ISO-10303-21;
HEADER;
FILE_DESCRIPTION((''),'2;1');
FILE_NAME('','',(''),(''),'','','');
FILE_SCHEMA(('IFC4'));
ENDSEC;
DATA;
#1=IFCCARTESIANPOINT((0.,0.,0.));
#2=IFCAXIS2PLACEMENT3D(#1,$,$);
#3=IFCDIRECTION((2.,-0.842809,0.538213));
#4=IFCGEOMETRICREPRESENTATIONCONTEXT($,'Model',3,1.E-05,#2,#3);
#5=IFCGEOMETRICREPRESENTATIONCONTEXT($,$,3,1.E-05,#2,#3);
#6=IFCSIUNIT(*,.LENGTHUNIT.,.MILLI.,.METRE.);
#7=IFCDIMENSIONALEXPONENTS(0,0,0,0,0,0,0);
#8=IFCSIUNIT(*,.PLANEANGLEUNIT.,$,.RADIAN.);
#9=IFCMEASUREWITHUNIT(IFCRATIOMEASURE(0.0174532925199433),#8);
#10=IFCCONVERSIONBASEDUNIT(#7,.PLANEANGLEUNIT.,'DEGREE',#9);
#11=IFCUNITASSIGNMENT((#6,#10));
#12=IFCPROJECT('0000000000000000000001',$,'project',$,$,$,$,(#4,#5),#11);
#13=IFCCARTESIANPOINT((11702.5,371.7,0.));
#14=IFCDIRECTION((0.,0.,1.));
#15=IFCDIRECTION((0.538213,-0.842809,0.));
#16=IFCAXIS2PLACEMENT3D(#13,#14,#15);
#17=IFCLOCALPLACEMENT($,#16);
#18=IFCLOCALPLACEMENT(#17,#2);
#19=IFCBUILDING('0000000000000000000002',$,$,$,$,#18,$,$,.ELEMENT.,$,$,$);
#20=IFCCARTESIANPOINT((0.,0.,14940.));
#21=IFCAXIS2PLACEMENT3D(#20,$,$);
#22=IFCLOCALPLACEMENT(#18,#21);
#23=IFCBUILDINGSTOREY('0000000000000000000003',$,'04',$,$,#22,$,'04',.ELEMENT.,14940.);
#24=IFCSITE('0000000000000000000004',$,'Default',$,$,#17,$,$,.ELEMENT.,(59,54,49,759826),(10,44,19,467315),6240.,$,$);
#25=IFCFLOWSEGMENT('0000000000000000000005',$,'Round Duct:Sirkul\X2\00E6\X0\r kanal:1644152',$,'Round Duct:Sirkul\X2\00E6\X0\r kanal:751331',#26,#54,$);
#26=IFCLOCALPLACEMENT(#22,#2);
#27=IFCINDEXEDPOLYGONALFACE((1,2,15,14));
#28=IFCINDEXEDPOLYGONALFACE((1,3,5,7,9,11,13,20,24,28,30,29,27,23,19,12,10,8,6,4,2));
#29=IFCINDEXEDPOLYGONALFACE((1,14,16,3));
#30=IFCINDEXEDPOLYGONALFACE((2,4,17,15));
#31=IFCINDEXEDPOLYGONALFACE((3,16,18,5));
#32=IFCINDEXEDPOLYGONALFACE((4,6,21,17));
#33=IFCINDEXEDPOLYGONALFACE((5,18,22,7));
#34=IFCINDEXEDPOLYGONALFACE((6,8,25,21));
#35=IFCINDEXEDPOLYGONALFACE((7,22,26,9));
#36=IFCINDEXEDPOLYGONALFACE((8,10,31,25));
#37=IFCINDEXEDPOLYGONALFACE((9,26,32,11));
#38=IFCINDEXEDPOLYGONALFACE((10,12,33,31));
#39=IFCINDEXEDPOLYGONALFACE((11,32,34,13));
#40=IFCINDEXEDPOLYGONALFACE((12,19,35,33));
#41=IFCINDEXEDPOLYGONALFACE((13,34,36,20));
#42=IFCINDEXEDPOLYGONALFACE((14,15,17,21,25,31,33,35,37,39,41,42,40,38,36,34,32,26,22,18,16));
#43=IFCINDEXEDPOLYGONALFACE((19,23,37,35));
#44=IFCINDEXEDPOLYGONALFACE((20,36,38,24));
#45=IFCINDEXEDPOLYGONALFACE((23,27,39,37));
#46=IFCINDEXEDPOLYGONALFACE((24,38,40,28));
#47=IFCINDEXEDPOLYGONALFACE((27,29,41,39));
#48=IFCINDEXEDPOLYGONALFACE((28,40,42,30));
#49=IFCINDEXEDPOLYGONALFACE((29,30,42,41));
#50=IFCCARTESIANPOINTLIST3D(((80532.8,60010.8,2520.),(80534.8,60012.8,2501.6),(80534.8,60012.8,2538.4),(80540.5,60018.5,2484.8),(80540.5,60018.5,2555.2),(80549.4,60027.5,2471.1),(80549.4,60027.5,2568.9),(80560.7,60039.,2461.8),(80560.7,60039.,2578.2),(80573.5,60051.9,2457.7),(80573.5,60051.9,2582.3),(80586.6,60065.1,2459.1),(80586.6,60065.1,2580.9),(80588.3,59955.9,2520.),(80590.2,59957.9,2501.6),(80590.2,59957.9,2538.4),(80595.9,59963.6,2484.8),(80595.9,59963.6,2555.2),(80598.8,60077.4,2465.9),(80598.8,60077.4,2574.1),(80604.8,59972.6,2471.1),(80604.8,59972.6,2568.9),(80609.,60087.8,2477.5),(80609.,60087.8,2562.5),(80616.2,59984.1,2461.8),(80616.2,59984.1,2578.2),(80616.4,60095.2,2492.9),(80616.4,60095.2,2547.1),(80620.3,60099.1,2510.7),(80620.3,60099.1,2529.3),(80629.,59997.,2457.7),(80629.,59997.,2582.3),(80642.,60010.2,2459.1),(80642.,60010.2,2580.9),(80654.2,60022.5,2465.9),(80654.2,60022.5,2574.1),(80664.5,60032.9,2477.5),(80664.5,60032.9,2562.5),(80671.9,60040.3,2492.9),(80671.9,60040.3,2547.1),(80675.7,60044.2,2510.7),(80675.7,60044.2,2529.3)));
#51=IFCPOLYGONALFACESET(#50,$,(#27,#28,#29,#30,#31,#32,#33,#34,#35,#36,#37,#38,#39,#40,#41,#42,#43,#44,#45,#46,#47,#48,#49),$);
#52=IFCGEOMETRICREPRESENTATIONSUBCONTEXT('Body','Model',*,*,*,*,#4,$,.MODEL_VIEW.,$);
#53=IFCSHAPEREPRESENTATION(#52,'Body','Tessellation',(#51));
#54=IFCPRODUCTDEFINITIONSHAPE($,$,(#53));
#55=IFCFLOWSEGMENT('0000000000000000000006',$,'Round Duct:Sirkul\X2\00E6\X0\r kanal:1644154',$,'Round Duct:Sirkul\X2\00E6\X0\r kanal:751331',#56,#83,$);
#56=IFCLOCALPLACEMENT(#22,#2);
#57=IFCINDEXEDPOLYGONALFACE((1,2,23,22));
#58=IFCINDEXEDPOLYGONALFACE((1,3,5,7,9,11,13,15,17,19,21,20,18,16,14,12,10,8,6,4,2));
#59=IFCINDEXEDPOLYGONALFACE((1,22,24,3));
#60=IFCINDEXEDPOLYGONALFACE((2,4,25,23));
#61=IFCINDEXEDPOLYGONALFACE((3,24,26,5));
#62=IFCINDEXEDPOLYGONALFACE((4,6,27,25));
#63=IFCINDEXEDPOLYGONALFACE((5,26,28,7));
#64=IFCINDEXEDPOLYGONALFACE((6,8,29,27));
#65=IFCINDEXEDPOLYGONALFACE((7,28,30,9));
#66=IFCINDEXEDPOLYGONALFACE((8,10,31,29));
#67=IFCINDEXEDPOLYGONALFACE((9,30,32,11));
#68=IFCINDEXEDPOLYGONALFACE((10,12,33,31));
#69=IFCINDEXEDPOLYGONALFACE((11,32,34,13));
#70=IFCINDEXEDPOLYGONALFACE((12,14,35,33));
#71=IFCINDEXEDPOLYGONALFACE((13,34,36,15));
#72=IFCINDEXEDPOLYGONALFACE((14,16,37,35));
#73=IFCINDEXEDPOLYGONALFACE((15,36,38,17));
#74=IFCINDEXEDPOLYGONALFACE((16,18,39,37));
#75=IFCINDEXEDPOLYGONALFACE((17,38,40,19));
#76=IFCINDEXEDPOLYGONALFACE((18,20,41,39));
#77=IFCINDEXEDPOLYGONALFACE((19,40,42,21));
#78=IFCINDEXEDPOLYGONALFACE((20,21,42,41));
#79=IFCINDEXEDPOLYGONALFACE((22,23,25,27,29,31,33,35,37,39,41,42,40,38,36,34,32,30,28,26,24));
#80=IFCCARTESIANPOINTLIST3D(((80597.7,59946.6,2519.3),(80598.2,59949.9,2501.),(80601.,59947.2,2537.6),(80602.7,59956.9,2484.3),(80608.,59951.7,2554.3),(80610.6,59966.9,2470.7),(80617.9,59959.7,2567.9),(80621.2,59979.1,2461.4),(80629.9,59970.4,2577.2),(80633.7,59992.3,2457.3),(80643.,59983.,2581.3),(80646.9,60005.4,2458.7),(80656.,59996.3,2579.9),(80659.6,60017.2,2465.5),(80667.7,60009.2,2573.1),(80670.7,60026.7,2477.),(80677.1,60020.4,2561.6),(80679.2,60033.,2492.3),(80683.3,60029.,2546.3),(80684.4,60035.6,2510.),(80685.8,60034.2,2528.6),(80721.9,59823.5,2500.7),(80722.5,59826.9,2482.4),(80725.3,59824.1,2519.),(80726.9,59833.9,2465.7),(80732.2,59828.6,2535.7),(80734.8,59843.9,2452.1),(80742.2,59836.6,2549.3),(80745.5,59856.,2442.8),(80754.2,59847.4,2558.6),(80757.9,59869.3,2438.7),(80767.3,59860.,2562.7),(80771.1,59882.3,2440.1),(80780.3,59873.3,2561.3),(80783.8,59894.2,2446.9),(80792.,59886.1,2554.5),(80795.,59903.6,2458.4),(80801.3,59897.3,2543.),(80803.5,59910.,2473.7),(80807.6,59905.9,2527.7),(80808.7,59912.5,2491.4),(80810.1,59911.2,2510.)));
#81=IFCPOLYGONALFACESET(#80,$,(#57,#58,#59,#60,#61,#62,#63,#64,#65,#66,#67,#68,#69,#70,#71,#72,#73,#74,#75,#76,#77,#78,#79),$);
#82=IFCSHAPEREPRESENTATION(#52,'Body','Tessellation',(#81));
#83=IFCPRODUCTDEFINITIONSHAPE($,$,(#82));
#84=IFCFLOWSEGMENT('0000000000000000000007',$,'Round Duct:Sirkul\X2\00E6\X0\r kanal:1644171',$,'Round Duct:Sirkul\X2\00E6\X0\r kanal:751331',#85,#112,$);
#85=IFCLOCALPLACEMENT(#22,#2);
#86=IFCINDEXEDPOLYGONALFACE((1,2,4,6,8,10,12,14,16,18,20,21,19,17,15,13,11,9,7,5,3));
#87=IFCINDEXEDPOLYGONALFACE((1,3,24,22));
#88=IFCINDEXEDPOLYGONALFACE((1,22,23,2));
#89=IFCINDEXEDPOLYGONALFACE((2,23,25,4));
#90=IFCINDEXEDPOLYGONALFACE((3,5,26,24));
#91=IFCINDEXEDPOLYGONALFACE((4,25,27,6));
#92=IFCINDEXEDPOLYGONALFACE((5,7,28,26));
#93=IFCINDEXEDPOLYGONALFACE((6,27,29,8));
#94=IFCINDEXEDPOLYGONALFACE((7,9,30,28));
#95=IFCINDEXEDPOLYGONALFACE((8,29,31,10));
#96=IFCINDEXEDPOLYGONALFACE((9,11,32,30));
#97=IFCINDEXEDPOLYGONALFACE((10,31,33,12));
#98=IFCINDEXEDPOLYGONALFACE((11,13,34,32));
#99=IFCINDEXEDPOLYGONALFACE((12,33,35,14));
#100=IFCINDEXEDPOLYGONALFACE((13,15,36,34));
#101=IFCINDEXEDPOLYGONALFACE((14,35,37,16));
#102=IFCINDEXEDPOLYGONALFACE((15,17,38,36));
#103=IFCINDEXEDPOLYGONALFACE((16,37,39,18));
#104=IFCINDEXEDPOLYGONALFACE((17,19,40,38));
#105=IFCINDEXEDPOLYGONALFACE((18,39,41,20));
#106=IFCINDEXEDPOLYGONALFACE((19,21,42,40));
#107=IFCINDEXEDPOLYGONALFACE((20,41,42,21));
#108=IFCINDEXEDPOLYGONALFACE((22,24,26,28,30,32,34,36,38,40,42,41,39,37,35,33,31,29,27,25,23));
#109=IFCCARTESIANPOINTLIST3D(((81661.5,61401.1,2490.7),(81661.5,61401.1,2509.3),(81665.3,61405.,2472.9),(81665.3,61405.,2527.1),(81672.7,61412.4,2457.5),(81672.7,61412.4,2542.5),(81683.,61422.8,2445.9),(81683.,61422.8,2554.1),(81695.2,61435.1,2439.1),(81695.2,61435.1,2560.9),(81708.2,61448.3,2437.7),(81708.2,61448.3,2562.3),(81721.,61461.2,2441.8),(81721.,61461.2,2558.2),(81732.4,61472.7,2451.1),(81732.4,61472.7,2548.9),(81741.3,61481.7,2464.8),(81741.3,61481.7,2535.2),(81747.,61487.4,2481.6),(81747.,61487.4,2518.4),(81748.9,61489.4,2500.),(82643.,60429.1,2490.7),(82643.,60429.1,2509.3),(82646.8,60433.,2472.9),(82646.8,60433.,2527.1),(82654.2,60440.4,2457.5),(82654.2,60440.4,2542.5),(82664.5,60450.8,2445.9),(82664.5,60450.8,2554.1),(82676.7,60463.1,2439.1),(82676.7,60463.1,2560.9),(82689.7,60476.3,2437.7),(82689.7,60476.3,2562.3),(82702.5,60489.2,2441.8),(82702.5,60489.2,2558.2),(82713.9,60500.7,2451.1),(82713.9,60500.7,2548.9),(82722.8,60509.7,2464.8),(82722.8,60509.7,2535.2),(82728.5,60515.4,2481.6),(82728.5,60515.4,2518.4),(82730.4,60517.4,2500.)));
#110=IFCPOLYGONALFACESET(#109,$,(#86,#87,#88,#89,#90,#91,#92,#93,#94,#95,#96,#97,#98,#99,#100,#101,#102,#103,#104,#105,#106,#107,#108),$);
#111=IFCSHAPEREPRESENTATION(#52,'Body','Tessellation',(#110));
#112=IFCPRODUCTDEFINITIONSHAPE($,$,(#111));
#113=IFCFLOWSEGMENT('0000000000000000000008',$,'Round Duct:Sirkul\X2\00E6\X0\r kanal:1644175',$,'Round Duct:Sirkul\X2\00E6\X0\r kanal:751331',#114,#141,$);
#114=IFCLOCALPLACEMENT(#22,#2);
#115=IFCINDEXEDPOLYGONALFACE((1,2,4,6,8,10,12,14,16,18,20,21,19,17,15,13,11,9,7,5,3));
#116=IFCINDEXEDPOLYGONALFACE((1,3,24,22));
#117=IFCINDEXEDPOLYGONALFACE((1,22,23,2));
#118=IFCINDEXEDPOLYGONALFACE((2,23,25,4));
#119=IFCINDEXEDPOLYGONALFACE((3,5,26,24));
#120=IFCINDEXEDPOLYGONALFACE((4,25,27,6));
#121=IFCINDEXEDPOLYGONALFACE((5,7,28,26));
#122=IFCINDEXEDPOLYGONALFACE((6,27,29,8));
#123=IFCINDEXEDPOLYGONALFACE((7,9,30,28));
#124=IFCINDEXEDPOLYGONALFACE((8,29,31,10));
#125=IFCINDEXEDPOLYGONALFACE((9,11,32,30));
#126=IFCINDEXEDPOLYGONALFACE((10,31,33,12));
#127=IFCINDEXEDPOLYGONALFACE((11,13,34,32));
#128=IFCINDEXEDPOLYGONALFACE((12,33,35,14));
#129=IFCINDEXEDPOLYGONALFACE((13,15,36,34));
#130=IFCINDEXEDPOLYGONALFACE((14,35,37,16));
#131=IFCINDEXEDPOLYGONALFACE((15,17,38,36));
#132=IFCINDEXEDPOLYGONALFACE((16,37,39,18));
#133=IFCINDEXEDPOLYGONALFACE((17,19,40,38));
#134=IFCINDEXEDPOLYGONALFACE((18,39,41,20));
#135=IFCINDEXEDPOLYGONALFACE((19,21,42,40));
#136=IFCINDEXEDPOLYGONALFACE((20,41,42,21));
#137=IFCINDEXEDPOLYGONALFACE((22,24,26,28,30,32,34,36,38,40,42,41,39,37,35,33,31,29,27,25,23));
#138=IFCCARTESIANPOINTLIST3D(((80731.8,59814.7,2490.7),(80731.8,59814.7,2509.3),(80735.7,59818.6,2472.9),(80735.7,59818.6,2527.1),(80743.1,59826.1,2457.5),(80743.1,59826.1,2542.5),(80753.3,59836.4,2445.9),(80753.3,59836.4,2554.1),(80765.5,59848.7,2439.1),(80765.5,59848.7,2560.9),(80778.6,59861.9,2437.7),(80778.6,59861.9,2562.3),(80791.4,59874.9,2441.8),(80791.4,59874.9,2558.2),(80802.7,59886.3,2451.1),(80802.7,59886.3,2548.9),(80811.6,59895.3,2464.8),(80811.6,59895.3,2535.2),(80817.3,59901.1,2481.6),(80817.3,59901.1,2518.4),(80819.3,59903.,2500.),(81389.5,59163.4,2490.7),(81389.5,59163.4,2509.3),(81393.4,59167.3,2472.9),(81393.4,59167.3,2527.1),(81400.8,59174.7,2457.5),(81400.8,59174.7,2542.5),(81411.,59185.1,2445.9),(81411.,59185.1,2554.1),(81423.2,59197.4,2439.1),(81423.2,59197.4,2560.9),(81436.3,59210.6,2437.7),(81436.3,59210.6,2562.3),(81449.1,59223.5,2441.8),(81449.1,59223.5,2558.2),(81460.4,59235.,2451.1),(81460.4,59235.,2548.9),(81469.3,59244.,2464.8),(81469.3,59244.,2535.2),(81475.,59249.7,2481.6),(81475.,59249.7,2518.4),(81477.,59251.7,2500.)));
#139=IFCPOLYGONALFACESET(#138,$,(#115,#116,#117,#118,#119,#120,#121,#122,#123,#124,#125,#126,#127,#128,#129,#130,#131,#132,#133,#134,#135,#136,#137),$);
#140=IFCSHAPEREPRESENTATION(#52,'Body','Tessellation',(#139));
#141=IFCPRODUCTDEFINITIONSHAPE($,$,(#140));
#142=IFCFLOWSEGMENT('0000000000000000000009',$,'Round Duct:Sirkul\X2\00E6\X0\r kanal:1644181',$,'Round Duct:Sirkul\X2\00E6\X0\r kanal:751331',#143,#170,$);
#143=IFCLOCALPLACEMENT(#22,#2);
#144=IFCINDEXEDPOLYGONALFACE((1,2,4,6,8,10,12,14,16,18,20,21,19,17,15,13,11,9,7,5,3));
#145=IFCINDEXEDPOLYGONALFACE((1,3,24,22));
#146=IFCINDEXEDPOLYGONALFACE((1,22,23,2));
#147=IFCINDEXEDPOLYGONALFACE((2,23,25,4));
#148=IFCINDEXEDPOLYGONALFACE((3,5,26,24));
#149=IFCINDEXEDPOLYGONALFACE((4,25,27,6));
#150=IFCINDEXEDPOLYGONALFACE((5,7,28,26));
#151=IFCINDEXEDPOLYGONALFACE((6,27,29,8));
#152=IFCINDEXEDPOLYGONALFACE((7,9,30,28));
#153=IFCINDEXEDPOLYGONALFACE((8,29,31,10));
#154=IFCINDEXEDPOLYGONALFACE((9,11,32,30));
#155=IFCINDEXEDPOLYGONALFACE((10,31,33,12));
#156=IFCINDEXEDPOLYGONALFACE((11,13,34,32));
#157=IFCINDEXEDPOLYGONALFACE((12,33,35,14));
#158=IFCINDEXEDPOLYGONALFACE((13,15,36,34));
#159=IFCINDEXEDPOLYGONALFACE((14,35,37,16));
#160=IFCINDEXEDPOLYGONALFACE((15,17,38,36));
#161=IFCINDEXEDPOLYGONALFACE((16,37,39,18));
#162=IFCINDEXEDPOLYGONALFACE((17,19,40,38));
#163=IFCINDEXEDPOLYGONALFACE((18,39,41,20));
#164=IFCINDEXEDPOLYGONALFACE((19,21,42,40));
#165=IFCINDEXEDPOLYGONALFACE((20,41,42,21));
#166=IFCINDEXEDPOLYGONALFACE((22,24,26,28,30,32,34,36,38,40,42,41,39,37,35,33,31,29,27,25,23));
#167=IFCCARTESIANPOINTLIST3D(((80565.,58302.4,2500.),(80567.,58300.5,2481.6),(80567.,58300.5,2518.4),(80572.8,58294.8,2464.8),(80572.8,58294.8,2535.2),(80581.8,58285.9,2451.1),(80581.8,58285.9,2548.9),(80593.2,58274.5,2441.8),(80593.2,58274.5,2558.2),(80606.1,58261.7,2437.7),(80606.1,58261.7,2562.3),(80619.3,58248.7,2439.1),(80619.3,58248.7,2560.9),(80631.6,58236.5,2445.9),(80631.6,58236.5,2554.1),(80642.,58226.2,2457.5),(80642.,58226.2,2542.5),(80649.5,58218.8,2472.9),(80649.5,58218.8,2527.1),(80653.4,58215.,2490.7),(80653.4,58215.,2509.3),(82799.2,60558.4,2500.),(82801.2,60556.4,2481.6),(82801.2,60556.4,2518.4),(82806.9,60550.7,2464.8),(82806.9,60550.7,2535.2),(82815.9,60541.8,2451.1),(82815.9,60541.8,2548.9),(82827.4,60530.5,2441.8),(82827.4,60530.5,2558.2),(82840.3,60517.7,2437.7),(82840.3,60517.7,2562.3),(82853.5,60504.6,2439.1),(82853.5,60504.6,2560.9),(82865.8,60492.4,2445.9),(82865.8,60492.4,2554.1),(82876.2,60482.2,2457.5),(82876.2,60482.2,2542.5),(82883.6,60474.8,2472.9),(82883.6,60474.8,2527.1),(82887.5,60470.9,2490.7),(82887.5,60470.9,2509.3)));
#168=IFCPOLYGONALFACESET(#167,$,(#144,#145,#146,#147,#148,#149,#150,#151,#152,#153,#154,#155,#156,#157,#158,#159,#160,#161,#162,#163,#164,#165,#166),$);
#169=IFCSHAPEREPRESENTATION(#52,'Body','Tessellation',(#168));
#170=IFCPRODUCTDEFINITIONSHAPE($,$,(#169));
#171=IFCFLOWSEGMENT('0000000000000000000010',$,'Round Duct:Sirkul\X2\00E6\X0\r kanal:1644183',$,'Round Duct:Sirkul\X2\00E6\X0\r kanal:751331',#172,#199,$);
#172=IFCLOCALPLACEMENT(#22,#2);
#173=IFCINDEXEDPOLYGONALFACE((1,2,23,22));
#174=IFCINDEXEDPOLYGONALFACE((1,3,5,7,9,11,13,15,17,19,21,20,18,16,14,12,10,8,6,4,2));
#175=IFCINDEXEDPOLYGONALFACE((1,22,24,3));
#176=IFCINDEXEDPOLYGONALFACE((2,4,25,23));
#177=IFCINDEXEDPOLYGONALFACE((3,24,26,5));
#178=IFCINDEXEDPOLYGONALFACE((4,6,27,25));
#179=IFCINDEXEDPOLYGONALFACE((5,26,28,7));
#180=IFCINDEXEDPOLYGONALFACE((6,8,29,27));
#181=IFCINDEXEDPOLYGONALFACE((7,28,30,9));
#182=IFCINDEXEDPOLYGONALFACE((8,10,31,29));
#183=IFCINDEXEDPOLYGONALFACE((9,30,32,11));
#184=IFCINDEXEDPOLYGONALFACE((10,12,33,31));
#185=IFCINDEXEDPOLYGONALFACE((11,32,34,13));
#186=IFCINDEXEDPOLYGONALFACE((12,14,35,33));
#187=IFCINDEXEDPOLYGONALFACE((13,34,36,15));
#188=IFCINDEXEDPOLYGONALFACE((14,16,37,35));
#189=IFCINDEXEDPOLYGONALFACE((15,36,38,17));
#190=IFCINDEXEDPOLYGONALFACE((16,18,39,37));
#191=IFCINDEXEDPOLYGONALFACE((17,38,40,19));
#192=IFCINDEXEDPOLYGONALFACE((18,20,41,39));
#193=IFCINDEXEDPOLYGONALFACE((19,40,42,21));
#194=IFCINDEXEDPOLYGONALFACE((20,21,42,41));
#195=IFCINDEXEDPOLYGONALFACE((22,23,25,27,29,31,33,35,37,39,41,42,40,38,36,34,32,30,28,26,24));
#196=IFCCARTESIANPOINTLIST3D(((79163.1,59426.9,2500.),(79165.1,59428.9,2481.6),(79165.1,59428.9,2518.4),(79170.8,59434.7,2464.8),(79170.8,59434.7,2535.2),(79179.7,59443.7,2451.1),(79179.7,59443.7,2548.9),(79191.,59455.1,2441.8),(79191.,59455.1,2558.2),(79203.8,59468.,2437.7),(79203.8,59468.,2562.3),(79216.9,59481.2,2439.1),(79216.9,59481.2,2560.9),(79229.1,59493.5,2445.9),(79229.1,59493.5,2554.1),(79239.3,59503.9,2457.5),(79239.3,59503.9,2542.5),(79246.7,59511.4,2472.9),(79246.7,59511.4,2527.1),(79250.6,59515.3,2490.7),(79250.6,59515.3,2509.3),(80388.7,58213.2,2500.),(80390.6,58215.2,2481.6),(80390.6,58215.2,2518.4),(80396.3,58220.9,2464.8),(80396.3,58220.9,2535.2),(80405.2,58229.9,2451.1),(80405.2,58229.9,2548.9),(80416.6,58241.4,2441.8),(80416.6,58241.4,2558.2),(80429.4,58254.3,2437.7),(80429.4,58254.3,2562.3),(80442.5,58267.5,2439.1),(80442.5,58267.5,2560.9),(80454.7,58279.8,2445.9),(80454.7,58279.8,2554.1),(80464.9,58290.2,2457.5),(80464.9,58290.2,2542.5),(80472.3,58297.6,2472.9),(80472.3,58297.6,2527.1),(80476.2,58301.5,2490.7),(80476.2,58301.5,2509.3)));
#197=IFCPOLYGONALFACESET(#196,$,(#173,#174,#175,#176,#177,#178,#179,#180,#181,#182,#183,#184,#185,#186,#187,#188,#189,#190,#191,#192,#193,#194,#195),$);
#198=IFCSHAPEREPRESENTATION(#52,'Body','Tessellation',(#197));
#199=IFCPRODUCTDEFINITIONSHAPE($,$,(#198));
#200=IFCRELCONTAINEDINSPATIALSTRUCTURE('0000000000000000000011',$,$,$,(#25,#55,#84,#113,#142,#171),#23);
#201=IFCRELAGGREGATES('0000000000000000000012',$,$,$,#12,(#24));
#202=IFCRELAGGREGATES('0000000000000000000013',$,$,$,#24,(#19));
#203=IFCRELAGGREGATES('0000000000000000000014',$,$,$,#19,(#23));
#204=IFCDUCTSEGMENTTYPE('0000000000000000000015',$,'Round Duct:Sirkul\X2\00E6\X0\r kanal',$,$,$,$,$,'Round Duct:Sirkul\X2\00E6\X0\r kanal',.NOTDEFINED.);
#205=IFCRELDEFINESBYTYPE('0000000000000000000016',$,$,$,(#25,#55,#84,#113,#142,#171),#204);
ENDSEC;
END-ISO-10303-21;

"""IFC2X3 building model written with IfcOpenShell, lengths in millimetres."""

from ifc_helpers import new_model, entity, si_unit, converted_unit, direction, frame, frame_2d, origin, origin_2d_with_axis, place, context, subcontext, project, spatial, circle, extrude, type_object, element, save


model = new_model("IFC2X3")

# Units and contexts
model_context = context("Model", 3, precision=1e-05, world=origin(), true_north=direction((2.0, -0.842809, 0.538213)))
context_of_model = context(None, 3, precision=1e-05, world=origin(), true_north=direction((2.0, -0.842809, 0.538213)))
body_context = subcontext(model_context, "Body", "Model", "MODEL_VIEW")
ifc_project = project(units=[si_unit("LENGTHUNIT", "METRE", prefix="MILLI"), converted_unit("PLANEANGLEUNIT", "DEGREE", entity("IfcRatioMeasure", 0.0174532925199433), si_unit("PLANEANGLEUNIT", "RADIAN"), dimensions=[0, 0, 0, 0, 0, 0, 0])], contexts=[model_context, context_of_model])

# Site, building, storey
site_placement = place(None, frame((11702.5, 371.7, 0.0), z_axis=(0.0, 0.0, 1.0), x_axis=(0.538213, -0.842809, 0.0)))
site = spatial("IfcSite", under=ifc_project, at=site_placement, Name="Default", CompositionType="ELEMENT", RefLatitude=(59, 54, 49, 759826), RefLongitude=(10, 44, 19, 467315), RefElevation=6240.0)
building_placement = place(site_placement, origin())
building = spatial("IfcBuilding", under=site, at=building_placement, CompositionType="ELEMENT")
storey_placement = place(building_placement, frame((0.0, 0.0, 14940.0)))
storey = spatial("IfcBuildingStorey", under=building, at=storey_placement, Name="04", LongName="04", CompositionType="ELEMENT", Elevation=14940.0)

# Flow segments
duct_segment_type_1 = type_object("IfcDuctSegmentType", Name="Round Duct:Sirkulær kanal", ElementType="Round Duct:Sirkulær kanal", PredefinedType="NOTDEFINED")
flow_segment_1_placement = place(storey_placement, origin())
element("IfcFlowSegment", 1, at=flow_segment_1_placement, inside=storey, type_object=duct_segment_type_1, Name="Round Duct:Sirkulær kanal:1644152", ObjectType="Round Duct:Sirkulær kanal:751331", context=body_context, shape_type="SweptSolid", body=[
    extrude(circle(Radius=62.5, at=origin_2d_with_axis()), frame((80632.3, 60000.3, 2520.0), z_axis=(-0.710528, 0.703669, 0.0), x_axis=(-0.703669, -0.710528, 0.0)), (0.0, 0.0, 1.0), 78.0),
])
flow_segment_2_placement = place(storey_placement, origin())
element("IfcFlowSegment", 2, at=flow_segment_2_placement, inside=storey, type_object=duct_segment_type_1, Name="Round Duct:Sirkulær kanal:1644154", ObjectType="Round Duct:Sirkulær kanal:751331", context=body_context, shape_type="SweptSolid", body=[
    extrude(circle(Radius=62.5, at=origin_2d_with_axis()), frame((80765.9, 59867.9, 2500.7), z_axis=(-0.706544, 0.699723, 0.105746), x_axis=(-0.703669, -0.710528, 0.0)), (0.0, 0.0, 1.0), 175.9),
])
flow_segment_3_placement = place(storey_placement, origin())
element("IfcFlowSegment", 3, at=flow_segment_3_placement, inside=storey, type_object=duct_segment_type_1, Name="Round Duct:Sirkulær kanal:1644171", ObjectType="Round Duct:Sirkulær kanal:751331", context=body_context, shape_type="SweptSolid", body=[
    extrude(circle(Radius=62.5, at=frame_2d((0.0, 0.0), x_axis=(1.0, 0.0))), frame((82686.5, 60473.0, 2500.0), z_axis=(-0.710528, 0.703669, 0.0), x_axis=(0.703669, 0.710528, 0.0)), (0.0, 0.0, 1.0), 1381.4),
])
flow_segment_4_placement = place(storey_placement, origin())
element("IfcFlowSegment", 4, at=flow_segment_4_placement, inside=storey, type_object=duct_segment_type_1, Name="Round Duct:Sirkulær kanal:1644175", ObjectType="Round Duct:Sirkulær kanal:751331", context=body_context, shape_type="SweptSolid", body=[
    extrude(circle(Radius=62.5, at=origin_2d_with_axis()), frame((80775.3, 59858.6, 2500.0), z_axis=(0.710528, -0.703669, 0.0), x_axis=(0.703669, 0.710528, 0.0)), (0.0, 0.0, 1.0), 925.6),
])
flow_segment_5_placement = place(storey_placement, origin())
element("IfcFlowSegment", 5, at=flow_segment_5_placement, inside=storey, type_object=duct_segment_type_1, Name="Round Duct:Sirkulær kanal:1644181", ObjectType="Round Duct:Sirkulær kanal:751331", context=body_context, shape_type="SweptSolid", body=[
    extrude(circle(Radius=62.5, at=origin_2d_with_axis()), frame((80609.4, 58258.5, 2500.0), z_axis=(0.703669, 0.710528, 0.0), x_axis=(-0.710528, 0.703669, 0.0)), (0.0, 0.0, 1.0), 3175.0),
])
flow_segment_6_placement = place(storey_placement, origin())
element("IfcFlowSegment", 6, at=flow_segment_6_placement, inside=storey, type_object=duct_segment_type_1, Name="Round Duct:Sirkulær kanal:1644183", ObjectType="Round Duct:Sirkulær kanal:751331", context=body_context, shape_type="SweptSolid", body=[
    extrude(circle(Radius=62.5, at=origin_2d_with_axis()), frame((80432.7, 58257.6, 2500.0), z_axis=(-0.710528, 0.703669, 0.0), x_axis=(-0.703669, -0.710528, 0.0)), (0.0, 0.0, 1.0), 1724.9),
])

save(model, "model.ifc")
